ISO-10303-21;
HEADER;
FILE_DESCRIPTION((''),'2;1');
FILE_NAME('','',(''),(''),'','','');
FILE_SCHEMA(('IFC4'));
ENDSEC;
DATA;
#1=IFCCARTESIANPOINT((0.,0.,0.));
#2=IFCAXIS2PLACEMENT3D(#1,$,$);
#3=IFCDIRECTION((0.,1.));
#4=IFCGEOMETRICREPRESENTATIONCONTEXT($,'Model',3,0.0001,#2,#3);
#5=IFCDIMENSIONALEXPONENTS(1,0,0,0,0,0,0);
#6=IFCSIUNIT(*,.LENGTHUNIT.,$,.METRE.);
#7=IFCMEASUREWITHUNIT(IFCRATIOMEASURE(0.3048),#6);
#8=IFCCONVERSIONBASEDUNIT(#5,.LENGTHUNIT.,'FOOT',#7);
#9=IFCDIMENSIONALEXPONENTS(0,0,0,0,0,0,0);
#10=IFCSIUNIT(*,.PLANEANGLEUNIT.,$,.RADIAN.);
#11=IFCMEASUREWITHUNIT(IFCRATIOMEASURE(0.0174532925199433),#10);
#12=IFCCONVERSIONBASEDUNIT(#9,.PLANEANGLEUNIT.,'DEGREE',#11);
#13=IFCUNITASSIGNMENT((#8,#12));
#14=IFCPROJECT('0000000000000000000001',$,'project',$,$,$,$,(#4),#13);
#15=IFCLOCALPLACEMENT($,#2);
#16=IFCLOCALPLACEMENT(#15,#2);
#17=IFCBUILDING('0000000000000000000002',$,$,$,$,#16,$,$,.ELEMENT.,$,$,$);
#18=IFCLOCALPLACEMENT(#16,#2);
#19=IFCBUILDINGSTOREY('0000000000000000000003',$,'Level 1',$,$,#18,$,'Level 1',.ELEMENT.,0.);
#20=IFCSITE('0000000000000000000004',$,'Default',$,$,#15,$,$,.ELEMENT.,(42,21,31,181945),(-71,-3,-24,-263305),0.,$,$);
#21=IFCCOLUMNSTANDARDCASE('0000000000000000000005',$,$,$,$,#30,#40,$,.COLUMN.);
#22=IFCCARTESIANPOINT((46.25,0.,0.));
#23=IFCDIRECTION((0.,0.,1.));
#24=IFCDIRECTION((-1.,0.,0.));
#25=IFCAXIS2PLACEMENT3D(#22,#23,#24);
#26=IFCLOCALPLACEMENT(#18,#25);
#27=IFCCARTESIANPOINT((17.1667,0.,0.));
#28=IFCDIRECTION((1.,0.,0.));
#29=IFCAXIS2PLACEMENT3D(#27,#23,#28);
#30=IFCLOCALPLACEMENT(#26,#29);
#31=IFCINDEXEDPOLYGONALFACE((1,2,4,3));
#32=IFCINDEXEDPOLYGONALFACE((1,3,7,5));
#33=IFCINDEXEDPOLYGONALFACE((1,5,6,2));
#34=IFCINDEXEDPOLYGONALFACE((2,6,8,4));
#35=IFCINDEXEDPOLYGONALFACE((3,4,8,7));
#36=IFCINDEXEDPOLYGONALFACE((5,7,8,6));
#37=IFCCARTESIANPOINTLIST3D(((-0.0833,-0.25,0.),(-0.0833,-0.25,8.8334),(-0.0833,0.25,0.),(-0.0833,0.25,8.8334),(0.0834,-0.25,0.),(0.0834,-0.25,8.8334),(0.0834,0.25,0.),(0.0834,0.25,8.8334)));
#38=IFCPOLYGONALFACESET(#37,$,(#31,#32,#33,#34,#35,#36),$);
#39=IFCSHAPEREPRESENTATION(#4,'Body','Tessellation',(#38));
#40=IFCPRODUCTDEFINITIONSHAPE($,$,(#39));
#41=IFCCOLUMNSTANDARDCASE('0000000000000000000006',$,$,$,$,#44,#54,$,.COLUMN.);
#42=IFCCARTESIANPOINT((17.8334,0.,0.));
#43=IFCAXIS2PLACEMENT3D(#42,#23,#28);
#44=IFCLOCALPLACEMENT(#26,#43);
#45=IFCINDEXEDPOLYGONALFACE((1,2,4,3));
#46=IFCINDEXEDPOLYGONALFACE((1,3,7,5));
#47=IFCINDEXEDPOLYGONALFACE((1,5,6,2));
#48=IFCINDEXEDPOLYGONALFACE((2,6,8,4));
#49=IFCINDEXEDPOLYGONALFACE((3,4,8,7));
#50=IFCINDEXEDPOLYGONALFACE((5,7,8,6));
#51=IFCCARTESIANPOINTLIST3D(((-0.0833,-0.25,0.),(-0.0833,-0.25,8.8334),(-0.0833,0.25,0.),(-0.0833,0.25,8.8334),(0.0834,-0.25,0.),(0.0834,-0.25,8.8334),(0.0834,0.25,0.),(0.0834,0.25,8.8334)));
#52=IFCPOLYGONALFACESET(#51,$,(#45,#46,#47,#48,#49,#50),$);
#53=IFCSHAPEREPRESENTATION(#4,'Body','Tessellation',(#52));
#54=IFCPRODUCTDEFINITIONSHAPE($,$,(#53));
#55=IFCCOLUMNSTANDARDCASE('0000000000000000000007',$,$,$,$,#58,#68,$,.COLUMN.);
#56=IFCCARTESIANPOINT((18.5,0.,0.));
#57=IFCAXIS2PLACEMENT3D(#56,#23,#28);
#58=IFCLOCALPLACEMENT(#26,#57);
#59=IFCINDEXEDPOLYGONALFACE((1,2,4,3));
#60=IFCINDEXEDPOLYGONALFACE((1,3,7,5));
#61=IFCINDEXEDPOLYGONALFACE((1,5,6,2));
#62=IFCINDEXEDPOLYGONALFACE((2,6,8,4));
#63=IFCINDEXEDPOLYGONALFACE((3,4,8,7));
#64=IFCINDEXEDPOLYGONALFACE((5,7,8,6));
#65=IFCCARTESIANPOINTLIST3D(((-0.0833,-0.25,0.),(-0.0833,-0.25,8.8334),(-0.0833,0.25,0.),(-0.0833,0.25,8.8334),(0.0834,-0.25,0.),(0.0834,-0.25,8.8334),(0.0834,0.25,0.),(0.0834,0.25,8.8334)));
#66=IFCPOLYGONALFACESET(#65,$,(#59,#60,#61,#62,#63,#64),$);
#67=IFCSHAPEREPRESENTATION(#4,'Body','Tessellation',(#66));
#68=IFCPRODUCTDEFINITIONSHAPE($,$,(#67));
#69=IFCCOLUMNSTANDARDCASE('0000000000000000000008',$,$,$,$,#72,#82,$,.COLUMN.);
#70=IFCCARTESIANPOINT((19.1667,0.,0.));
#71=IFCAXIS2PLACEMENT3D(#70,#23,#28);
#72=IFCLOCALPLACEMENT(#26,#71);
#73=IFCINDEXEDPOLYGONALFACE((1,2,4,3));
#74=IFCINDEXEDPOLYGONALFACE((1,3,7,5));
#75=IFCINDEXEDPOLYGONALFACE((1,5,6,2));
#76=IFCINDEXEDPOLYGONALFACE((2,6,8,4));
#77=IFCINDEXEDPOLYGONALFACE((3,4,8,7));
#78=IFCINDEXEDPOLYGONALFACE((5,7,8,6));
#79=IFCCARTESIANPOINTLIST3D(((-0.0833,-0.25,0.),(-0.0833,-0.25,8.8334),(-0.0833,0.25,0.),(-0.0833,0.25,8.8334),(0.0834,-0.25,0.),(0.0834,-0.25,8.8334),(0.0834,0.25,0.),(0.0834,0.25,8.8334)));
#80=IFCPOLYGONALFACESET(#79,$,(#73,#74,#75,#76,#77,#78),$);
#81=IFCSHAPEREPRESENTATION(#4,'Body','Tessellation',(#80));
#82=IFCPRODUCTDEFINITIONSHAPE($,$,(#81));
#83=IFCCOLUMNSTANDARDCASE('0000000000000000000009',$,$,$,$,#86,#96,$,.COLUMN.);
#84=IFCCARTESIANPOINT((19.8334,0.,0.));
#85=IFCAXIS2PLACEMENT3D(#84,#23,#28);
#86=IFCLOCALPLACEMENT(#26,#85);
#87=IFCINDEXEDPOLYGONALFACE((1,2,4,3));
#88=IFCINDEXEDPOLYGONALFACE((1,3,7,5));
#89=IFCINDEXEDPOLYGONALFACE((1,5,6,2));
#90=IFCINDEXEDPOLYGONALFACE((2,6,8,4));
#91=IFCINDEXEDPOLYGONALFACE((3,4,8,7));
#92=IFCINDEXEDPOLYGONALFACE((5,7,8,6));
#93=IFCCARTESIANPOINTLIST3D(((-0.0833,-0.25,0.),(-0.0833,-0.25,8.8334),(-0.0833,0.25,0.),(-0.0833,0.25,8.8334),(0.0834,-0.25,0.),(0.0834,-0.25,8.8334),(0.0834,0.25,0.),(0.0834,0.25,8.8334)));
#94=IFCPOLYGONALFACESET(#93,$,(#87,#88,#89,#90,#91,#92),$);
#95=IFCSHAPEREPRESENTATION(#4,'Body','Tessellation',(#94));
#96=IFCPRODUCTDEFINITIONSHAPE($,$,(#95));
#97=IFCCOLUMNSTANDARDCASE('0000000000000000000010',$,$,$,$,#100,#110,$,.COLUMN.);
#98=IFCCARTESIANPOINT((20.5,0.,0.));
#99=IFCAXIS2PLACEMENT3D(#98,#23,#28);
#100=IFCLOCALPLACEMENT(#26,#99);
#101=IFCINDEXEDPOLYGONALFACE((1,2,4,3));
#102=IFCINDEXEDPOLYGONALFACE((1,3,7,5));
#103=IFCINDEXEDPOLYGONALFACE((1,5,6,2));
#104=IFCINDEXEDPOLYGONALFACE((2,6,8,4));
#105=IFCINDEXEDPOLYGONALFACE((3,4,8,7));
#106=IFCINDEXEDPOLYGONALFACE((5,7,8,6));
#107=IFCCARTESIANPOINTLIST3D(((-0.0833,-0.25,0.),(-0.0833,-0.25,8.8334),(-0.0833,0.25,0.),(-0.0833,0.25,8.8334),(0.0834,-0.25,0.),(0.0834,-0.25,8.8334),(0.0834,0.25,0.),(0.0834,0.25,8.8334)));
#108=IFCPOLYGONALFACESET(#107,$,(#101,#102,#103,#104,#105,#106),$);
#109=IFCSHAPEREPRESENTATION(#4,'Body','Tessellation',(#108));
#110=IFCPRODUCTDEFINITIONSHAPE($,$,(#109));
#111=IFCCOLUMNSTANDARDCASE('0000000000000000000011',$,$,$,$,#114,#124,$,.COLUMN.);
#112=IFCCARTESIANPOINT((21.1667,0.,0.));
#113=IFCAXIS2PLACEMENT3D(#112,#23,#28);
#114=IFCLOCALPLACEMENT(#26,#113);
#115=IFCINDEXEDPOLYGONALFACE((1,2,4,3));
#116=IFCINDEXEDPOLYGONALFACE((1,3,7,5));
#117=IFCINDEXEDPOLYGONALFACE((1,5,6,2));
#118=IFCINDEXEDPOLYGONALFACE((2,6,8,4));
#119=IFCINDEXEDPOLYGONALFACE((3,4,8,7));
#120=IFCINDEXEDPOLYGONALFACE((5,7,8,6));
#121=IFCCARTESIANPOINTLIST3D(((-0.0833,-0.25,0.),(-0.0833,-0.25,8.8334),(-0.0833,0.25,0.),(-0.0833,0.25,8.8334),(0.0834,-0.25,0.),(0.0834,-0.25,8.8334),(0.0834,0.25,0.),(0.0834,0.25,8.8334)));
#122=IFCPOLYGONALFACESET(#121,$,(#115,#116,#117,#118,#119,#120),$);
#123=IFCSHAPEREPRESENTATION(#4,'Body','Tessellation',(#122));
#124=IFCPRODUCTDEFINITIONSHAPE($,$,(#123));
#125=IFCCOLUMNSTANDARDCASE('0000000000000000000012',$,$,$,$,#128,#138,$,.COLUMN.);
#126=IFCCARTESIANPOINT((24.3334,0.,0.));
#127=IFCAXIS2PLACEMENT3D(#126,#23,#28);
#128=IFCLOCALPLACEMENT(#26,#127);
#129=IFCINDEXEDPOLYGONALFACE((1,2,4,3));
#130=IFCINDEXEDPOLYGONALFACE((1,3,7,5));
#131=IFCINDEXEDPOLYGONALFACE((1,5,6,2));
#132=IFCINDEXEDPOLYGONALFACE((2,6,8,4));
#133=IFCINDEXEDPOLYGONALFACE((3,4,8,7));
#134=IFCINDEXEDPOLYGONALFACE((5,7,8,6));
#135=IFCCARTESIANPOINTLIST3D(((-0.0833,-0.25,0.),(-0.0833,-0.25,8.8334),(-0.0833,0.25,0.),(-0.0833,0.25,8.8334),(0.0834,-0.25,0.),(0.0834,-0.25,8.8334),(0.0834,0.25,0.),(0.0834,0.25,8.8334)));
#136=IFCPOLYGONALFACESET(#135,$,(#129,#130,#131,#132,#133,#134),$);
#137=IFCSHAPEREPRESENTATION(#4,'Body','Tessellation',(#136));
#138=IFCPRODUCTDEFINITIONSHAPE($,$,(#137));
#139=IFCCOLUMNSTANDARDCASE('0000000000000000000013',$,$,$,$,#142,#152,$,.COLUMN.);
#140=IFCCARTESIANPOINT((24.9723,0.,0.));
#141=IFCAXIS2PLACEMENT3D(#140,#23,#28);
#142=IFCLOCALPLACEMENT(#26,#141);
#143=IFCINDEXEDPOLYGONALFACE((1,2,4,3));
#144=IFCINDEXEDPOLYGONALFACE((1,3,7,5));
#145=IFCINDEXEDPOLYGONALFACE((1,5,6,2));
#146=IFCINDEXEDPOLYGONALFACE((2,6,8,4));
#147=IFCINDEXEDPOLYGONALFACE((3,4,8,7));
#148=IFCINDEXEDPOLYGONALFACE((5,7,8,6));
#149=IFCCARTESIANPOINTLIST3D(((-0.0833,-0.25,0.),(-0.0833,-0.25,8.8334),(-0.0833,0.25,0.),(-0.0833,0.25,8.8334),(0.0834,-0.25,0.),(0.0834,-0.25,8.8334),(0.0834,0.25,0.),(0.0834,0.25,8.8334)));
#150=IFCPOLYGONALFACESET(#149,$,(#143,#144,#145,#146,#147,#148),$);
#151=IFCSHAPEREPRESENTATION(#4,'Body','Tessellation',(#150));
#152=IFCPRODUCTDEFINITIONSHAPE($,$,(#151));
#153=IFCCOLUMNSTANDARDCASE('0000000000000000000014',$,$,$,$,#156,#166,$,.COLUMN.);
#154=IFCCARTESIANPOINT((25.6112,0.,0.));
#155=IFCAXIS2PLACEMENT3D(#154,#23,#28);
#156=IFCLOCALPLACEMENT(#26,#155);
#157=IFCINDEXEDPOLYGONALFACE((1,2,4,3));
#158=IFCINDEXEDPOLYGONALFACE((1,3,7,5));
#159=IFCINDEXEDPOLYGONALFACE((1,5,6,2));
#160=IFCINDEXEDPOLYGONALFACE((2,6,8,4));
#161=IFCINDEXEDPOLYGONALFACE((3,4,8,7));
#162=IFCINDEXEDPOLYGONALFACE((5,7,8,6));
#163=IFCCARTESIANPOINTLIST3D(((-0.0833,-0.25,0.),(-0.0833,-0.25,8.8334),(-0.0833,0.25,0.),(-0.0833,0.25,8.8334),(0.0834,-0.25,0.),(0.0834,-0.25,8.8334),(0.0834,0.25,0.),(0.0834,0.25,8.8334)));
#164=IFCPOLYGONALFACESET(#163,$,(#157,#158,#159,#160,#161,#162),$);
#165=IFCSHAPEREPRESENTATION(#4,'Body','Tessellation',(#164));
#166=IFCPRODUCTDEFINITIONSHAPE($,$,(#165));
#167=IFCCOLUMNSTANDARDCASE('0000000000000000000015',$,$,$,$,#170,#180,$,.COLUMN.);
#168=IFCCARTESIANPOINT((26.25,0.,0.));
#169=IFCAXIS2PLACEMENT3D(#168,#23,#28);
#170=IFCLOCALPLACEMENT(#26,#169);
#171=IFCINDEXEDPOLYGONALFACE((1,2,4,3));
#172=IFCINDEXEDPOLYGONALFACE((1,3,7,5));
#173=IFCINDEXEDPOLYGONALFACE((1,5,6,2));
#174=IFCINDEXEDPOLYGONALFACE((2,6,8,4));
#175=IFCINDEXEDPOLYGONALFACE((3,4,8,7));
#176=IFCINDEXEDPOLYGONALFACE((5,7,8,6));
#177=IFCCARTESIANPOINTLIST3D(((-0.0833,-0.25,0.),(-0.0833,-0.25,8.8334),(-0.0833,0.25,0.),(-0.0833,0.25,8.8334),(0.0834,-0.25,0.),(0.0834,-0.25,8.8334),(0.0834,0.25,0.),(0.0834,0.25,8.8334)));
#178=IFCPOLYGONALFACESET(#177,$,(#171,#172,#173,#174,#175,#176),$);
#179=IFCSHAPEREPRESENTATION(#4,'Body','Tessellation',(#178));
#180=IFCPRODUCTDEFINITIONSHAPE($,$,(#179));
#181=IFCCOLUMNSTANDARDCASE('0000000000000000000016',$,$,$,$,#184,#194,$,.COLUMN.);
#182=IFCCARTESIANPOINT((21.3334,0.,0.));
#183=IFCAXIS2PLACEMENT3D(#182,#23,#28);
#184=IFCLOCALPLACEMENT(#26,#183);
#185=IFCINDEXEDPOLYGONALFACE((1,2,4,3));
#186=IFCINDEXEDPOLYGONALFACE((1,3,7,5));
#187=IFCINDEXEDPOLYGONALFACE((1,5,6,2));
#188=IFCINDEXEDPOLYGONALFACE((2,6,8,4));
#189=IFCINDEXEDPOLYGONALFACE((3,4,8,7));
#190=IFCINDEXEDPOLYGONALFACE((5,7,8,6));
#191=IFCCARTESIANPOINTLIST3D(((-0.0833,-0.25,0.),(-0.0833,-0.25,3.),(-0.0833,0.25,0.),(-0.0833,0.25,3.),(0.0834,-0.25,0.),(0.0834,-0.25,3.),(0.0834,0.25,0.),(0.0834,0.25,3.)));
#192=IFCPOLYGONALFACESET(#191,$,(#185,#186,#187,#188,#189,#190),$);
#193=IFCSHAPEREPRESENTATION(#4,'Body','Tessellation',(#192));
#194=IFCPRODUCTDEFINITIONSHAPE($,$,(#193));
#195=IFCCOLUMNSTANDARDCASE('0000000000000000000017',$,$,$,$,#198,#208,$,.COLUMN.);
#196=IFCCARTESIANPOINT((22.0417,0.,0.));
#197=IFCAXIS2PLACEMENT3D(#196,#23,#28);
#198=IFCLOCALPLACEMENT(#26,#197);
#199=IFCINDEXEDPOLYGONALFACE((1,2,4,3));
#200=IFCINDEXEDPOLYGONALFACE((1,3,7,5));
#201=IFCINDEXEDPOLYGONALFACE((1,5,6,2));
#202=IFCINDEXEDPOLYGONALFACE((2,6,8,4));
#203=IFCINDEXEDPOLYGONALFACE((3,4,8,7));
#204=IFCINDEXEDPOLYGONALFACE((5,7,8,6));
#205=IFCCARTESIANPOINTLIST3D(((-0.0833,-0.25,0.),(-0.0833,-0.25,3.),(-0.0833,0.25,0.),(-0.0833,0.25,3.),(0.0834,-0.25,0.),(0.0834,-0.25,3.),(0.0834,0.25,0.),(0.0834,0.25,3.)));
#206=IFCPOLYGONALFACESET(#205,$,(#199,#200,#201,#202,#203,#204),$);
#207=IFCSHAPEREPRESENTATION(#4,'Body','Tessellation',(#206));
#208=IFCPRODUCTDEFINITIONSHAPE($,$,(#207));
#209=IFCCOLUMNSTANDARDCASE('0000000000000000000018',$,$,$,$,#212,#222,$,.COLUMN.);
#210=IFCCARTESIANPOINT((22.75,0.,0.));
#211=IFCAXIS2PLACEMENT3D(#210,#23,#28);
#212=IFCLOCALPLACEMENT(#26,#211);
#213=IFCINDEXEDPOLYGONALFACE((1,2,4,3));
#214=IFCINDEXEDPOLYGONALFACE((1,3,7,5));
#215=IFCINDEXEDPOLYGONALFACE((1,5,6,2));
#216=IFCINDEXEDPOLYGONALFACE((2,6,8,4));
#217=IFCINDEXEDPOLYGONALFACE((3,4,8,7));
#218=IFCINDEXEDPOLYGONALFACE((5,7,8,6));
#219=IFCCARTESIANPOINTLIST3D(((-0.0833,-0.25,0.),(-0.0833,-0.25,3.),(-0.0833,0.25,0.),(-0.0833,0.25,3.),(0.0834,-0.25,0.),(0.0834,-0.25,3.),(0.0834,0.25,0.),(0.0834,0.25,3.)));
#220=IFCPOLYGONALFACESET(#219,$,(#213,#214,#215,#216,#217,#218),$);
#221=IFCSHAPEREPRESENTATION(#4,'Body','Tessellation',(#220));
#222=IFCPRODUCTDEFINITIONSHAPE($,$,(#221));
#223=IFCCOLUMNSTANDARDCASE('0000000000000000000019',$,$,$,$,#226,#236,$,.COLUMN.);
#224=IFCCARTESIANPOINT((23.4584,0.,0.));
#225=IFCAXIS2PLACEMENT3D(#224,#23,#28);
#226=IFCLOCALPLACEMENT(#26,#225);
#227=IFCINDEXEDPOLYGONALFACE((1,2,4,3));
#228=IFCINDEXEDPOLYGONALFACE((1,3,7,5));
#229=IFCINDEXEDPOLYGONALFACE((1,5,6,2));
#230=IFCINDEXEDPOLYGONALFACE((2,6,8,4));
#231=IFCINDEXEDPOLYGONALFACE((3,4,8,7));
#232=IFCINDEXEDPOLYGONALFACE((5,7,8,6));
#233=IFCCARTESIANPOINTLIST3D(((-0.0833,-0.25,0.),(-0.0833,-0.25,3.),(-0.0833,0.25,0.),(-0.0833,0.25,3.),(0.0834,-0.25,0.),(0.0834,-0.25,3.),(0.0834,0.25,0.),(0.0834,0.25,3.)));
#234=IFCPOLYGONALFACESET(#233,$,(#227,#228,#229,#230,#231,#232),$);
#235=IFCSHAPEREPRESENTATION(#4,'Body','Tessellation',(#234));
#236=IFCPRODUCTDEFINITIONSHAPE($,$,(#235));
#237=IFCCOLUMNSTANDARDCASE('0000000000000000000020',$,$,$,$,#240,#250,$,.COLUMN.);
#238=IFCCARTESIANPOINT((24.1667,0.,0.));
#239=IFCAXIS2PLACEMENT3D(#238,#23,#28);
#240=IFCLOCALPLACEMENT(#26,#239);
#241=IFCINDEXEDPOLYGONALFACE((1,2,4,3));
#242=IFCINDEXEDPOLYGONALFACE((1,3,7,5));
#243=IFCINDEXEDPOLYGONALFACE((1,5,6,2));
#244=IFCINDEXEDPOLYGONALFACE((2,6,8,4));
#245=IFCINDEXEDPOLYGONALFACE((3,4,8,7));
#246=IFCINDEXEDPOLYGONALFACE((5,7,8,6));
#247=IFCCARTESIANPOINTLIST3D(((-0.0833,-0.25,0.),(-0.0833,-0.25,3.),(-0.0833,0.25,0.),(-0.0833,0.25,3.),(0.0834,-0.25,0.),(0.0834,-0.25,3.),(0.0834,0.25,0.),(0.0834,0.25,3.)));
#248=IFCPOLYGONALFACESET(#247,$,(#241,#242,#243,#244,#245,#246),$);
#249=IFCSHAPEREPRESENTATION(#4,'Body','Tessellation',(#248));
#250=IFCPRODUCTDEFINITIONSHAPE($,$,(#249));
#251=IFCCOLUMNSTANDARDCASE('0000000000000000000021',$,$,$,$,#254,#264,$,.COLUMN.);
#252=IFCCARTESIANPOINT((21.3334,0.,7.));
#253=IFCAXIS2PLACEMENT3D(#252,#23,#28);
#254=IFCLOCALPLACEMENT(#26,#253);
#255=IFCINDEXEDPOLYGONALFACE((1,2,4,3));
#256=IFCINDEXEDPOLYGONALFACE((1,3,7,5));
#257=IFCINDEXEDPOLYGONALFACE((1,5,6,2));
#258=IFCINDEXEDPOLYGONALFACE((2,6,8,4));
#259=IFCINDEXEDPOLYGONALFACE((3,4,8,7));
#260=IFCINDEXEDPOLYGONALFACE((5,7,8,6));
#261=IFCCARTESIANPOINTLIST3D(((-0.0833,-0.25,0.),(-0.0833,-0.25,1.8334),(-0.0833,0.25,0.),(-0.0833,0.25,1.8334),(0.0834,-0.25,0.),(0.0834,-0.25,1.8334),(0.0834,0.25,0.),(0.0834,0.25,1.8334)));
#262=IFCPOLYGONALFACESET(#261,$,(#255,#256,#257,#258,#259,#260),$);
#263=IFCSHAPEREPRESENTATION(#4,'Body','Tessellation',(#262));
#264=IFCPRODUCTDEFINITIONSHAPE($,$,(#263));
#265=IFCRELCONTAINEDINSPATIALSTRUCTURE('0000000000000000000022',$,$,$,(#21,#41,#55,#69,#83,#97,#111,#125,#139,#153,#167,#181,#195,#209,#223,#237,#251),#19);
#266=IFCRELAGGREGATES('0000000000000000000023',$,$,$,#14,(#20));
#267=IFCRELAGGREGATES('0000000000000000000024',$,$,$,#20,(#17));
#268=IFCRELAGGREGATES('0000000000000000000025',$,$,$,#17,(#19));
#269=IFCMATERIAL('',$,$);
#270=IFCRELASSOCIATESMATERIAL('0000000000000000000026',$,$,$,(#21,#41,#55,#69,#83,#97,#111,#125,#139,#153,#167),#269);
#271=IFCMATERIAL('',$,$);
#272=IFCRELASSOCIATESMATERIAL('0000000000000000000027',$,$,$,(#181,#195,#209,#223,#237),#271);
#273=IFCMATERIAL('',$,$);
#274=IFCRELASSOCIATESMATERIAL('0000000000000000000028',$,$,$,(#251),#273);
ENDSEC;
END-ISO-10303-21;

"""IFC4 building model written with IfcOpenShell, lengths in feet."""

from ifc_helpers import new_model, entity, si_unit, converted_unit, direction, frame, origin, place, context, project, spatial, rectangle, extrude, material, element, save


model = new_model("IFC4")

# Units and contexts
model_context = context("Model", 3, precision=0.0001, world=origin(), true_north=direction((0.0, 1.0)))
ifc_project = project(units=[converted_unit("LENGTHUNIT", "FOOT", entity("IfcRatioMeasure", 0.3048), si_unit("LENGTHUNIT", "METRE"), dimensions=[1, 0, 0, 0, 0, 0, 0]), converted_unit("PLANEANGLEUNIT", "DEGREE", entity("IfcRatioMeasure", 0.0174532925199433), si_unit("PLANEANGLEUNIT", "RADIAN"), dimensions=[0, 0, 0, 0, 0, 0, 0])], contexts=[model_context])

# Site, building, storey
site_placement = place(None, origin())
site = spatial("IfcSite", under=ifc_project, at=site_placement, Name="Default", CompositionType="ELEMENT", RefLatitude=(42, 21, 31, 181945), RefLongitude=(-71, -3, -24, -263305), RefElevation=0.0)
building_placement = place(site_placement, origin())
building = spatial("IfcBuilding", under=site, at=building_placement, CompositionType="ELEMENT")
storey_placement = place(building_placement, origin())
storey = spatial("IfcBuildingStorey", under=building, at=storey_placement, Name="Level 1", LongName="Level 1", CompositionType="ELEMENT", Elevation=0.0)

# Columns
ifc_material_1 = material(Name="")
placement_1 = place(storey_placement, frame((46.25, 0.0, 0.0), z_axis=(0.0, 0.0, 1.0), x_axis=(-1.0, 0.0, 0.0)))
for number, where, z_axis, x_axis in (
    (1, (17.1667, 0.0, 0.0), (0.0, 0.0, 1.0), (1.0, 0.0, 0.0)),
    (2, (17.8334, 0.0, 0.0), (0.0, 0.0, 1.0), (1.0, 0.0, 0.0)),
    (3, (18.5, 0.0, 0.0), (0.0, 0.0, 1.0), (1.0, 0.0, 0.0)),
    (4, (19.1667, 0.0, 0.0), (0.0, 0.0, 1.0), (1.0, 0.0, 0.0)),
    (5, (19.8334, 0.0, 0.0), (0.0, 0.0, 1.0), (1.0, 0.0, 0.0)),
    (6, (20.5, 0.0, 0.0), (0.0, 0.0, 1.0), (1.0, 0.0, 0.0)),
    (7, (21.1667, 0.0, 0.0), (0.0, 0.0, 1.0), (1.0, 0.0, 0.0)),
    (8, (24.3334, 0.0, 0.0), (0.0, 0.0, 1.0), (1.0, 0.0, 0.0)),
    (9, (24.9723, 0.0, 0.0), (0.0, 0.0, 1.0), (1.0, 0.0, 0.0)),
    (10, (25.6112, 0.0, 0.0), (0.0, 0.0, 1.0), (1.0, 0.0, 0.0)),
    (11, (26.25, 0.0, 0.0), (0.0, 0.0, 1.0), (1.0, 0.0, 0.0)),
):
    element("IfcColumnStandardCase", number, at=place(placement_1, frame(where, z_axis=z_axis, x_axis=x_axis)), inside=storey, material=ifc_material_1, PredefinedType="COLUMN", context=model_context, shape_type="SweptSolid", body=[
        extrude(rectangle(XDim=0.1667, YDim=0.5), origin(), (0.0, 0.0, 1.0), 8.8334),
    ])
ifc_material_2 = material(Name="")
for number, where, z_axis, x_axis in (
    (12, (21.3334, 0.0, 0.0), (0.0, 0.0, 1.0), (1.0, 0.0, 0.0)),
    (13, (22.0417, 0.0, 0.0), (0.0, 0.0, 1.0), (1.0, 0.0, 0.0)),
    (14, (22.75, 0.0, 0.0), (0.0, 0.0, 1.0), (1.0, 0.0, 0.0)),
    (15, (23.4584, 0.0, 0.0), (0.0, 0.0, 1.0), (1.0, 0.0, 0.0)),
    (16, (24.1667, 0.0, 0.0), (0.0, 0.0, 1.0), (1.0, 0.0, 0.0)),
):
    element("IfcColumnStandardCase", number, at=place(placement_1, frame(where, z_axis=z_axis, x_axis=x_axis)), inside=storey, material=ifc_material_2, PredefinedType="COLUMN", context=model_context, shape_type="SweptSolid", body=[
        extrude(rectangle(XDim=0.1667, YDim=0.5), origin(), (0.0, 0.0, 1.0), 3.0),
    ])
ifc_material_3 = material(Name="")
for number, where, z_axis, x_axis in (
    (17, (21.3334, 0.0, 7.0), (0.0, 0.0, 1.0), (1.0, 0.0, 0.0)),
):
    element("IfcColumnStandardCase", number, at=place(placement_1, frame(where, z_axis=z_axis, x_axis=x_axis)), inside=storey, material=ifc_material_3, PredefinedType="COLUMN", context=model_context, shape_type="SweptSolid", body=[
        extrude(rectangle(XDim=0.1667, YDim=0.5), origin(), (0.0, 0.0, 1.0), 1.8334),
    ])

save(model, "model.ifc")
